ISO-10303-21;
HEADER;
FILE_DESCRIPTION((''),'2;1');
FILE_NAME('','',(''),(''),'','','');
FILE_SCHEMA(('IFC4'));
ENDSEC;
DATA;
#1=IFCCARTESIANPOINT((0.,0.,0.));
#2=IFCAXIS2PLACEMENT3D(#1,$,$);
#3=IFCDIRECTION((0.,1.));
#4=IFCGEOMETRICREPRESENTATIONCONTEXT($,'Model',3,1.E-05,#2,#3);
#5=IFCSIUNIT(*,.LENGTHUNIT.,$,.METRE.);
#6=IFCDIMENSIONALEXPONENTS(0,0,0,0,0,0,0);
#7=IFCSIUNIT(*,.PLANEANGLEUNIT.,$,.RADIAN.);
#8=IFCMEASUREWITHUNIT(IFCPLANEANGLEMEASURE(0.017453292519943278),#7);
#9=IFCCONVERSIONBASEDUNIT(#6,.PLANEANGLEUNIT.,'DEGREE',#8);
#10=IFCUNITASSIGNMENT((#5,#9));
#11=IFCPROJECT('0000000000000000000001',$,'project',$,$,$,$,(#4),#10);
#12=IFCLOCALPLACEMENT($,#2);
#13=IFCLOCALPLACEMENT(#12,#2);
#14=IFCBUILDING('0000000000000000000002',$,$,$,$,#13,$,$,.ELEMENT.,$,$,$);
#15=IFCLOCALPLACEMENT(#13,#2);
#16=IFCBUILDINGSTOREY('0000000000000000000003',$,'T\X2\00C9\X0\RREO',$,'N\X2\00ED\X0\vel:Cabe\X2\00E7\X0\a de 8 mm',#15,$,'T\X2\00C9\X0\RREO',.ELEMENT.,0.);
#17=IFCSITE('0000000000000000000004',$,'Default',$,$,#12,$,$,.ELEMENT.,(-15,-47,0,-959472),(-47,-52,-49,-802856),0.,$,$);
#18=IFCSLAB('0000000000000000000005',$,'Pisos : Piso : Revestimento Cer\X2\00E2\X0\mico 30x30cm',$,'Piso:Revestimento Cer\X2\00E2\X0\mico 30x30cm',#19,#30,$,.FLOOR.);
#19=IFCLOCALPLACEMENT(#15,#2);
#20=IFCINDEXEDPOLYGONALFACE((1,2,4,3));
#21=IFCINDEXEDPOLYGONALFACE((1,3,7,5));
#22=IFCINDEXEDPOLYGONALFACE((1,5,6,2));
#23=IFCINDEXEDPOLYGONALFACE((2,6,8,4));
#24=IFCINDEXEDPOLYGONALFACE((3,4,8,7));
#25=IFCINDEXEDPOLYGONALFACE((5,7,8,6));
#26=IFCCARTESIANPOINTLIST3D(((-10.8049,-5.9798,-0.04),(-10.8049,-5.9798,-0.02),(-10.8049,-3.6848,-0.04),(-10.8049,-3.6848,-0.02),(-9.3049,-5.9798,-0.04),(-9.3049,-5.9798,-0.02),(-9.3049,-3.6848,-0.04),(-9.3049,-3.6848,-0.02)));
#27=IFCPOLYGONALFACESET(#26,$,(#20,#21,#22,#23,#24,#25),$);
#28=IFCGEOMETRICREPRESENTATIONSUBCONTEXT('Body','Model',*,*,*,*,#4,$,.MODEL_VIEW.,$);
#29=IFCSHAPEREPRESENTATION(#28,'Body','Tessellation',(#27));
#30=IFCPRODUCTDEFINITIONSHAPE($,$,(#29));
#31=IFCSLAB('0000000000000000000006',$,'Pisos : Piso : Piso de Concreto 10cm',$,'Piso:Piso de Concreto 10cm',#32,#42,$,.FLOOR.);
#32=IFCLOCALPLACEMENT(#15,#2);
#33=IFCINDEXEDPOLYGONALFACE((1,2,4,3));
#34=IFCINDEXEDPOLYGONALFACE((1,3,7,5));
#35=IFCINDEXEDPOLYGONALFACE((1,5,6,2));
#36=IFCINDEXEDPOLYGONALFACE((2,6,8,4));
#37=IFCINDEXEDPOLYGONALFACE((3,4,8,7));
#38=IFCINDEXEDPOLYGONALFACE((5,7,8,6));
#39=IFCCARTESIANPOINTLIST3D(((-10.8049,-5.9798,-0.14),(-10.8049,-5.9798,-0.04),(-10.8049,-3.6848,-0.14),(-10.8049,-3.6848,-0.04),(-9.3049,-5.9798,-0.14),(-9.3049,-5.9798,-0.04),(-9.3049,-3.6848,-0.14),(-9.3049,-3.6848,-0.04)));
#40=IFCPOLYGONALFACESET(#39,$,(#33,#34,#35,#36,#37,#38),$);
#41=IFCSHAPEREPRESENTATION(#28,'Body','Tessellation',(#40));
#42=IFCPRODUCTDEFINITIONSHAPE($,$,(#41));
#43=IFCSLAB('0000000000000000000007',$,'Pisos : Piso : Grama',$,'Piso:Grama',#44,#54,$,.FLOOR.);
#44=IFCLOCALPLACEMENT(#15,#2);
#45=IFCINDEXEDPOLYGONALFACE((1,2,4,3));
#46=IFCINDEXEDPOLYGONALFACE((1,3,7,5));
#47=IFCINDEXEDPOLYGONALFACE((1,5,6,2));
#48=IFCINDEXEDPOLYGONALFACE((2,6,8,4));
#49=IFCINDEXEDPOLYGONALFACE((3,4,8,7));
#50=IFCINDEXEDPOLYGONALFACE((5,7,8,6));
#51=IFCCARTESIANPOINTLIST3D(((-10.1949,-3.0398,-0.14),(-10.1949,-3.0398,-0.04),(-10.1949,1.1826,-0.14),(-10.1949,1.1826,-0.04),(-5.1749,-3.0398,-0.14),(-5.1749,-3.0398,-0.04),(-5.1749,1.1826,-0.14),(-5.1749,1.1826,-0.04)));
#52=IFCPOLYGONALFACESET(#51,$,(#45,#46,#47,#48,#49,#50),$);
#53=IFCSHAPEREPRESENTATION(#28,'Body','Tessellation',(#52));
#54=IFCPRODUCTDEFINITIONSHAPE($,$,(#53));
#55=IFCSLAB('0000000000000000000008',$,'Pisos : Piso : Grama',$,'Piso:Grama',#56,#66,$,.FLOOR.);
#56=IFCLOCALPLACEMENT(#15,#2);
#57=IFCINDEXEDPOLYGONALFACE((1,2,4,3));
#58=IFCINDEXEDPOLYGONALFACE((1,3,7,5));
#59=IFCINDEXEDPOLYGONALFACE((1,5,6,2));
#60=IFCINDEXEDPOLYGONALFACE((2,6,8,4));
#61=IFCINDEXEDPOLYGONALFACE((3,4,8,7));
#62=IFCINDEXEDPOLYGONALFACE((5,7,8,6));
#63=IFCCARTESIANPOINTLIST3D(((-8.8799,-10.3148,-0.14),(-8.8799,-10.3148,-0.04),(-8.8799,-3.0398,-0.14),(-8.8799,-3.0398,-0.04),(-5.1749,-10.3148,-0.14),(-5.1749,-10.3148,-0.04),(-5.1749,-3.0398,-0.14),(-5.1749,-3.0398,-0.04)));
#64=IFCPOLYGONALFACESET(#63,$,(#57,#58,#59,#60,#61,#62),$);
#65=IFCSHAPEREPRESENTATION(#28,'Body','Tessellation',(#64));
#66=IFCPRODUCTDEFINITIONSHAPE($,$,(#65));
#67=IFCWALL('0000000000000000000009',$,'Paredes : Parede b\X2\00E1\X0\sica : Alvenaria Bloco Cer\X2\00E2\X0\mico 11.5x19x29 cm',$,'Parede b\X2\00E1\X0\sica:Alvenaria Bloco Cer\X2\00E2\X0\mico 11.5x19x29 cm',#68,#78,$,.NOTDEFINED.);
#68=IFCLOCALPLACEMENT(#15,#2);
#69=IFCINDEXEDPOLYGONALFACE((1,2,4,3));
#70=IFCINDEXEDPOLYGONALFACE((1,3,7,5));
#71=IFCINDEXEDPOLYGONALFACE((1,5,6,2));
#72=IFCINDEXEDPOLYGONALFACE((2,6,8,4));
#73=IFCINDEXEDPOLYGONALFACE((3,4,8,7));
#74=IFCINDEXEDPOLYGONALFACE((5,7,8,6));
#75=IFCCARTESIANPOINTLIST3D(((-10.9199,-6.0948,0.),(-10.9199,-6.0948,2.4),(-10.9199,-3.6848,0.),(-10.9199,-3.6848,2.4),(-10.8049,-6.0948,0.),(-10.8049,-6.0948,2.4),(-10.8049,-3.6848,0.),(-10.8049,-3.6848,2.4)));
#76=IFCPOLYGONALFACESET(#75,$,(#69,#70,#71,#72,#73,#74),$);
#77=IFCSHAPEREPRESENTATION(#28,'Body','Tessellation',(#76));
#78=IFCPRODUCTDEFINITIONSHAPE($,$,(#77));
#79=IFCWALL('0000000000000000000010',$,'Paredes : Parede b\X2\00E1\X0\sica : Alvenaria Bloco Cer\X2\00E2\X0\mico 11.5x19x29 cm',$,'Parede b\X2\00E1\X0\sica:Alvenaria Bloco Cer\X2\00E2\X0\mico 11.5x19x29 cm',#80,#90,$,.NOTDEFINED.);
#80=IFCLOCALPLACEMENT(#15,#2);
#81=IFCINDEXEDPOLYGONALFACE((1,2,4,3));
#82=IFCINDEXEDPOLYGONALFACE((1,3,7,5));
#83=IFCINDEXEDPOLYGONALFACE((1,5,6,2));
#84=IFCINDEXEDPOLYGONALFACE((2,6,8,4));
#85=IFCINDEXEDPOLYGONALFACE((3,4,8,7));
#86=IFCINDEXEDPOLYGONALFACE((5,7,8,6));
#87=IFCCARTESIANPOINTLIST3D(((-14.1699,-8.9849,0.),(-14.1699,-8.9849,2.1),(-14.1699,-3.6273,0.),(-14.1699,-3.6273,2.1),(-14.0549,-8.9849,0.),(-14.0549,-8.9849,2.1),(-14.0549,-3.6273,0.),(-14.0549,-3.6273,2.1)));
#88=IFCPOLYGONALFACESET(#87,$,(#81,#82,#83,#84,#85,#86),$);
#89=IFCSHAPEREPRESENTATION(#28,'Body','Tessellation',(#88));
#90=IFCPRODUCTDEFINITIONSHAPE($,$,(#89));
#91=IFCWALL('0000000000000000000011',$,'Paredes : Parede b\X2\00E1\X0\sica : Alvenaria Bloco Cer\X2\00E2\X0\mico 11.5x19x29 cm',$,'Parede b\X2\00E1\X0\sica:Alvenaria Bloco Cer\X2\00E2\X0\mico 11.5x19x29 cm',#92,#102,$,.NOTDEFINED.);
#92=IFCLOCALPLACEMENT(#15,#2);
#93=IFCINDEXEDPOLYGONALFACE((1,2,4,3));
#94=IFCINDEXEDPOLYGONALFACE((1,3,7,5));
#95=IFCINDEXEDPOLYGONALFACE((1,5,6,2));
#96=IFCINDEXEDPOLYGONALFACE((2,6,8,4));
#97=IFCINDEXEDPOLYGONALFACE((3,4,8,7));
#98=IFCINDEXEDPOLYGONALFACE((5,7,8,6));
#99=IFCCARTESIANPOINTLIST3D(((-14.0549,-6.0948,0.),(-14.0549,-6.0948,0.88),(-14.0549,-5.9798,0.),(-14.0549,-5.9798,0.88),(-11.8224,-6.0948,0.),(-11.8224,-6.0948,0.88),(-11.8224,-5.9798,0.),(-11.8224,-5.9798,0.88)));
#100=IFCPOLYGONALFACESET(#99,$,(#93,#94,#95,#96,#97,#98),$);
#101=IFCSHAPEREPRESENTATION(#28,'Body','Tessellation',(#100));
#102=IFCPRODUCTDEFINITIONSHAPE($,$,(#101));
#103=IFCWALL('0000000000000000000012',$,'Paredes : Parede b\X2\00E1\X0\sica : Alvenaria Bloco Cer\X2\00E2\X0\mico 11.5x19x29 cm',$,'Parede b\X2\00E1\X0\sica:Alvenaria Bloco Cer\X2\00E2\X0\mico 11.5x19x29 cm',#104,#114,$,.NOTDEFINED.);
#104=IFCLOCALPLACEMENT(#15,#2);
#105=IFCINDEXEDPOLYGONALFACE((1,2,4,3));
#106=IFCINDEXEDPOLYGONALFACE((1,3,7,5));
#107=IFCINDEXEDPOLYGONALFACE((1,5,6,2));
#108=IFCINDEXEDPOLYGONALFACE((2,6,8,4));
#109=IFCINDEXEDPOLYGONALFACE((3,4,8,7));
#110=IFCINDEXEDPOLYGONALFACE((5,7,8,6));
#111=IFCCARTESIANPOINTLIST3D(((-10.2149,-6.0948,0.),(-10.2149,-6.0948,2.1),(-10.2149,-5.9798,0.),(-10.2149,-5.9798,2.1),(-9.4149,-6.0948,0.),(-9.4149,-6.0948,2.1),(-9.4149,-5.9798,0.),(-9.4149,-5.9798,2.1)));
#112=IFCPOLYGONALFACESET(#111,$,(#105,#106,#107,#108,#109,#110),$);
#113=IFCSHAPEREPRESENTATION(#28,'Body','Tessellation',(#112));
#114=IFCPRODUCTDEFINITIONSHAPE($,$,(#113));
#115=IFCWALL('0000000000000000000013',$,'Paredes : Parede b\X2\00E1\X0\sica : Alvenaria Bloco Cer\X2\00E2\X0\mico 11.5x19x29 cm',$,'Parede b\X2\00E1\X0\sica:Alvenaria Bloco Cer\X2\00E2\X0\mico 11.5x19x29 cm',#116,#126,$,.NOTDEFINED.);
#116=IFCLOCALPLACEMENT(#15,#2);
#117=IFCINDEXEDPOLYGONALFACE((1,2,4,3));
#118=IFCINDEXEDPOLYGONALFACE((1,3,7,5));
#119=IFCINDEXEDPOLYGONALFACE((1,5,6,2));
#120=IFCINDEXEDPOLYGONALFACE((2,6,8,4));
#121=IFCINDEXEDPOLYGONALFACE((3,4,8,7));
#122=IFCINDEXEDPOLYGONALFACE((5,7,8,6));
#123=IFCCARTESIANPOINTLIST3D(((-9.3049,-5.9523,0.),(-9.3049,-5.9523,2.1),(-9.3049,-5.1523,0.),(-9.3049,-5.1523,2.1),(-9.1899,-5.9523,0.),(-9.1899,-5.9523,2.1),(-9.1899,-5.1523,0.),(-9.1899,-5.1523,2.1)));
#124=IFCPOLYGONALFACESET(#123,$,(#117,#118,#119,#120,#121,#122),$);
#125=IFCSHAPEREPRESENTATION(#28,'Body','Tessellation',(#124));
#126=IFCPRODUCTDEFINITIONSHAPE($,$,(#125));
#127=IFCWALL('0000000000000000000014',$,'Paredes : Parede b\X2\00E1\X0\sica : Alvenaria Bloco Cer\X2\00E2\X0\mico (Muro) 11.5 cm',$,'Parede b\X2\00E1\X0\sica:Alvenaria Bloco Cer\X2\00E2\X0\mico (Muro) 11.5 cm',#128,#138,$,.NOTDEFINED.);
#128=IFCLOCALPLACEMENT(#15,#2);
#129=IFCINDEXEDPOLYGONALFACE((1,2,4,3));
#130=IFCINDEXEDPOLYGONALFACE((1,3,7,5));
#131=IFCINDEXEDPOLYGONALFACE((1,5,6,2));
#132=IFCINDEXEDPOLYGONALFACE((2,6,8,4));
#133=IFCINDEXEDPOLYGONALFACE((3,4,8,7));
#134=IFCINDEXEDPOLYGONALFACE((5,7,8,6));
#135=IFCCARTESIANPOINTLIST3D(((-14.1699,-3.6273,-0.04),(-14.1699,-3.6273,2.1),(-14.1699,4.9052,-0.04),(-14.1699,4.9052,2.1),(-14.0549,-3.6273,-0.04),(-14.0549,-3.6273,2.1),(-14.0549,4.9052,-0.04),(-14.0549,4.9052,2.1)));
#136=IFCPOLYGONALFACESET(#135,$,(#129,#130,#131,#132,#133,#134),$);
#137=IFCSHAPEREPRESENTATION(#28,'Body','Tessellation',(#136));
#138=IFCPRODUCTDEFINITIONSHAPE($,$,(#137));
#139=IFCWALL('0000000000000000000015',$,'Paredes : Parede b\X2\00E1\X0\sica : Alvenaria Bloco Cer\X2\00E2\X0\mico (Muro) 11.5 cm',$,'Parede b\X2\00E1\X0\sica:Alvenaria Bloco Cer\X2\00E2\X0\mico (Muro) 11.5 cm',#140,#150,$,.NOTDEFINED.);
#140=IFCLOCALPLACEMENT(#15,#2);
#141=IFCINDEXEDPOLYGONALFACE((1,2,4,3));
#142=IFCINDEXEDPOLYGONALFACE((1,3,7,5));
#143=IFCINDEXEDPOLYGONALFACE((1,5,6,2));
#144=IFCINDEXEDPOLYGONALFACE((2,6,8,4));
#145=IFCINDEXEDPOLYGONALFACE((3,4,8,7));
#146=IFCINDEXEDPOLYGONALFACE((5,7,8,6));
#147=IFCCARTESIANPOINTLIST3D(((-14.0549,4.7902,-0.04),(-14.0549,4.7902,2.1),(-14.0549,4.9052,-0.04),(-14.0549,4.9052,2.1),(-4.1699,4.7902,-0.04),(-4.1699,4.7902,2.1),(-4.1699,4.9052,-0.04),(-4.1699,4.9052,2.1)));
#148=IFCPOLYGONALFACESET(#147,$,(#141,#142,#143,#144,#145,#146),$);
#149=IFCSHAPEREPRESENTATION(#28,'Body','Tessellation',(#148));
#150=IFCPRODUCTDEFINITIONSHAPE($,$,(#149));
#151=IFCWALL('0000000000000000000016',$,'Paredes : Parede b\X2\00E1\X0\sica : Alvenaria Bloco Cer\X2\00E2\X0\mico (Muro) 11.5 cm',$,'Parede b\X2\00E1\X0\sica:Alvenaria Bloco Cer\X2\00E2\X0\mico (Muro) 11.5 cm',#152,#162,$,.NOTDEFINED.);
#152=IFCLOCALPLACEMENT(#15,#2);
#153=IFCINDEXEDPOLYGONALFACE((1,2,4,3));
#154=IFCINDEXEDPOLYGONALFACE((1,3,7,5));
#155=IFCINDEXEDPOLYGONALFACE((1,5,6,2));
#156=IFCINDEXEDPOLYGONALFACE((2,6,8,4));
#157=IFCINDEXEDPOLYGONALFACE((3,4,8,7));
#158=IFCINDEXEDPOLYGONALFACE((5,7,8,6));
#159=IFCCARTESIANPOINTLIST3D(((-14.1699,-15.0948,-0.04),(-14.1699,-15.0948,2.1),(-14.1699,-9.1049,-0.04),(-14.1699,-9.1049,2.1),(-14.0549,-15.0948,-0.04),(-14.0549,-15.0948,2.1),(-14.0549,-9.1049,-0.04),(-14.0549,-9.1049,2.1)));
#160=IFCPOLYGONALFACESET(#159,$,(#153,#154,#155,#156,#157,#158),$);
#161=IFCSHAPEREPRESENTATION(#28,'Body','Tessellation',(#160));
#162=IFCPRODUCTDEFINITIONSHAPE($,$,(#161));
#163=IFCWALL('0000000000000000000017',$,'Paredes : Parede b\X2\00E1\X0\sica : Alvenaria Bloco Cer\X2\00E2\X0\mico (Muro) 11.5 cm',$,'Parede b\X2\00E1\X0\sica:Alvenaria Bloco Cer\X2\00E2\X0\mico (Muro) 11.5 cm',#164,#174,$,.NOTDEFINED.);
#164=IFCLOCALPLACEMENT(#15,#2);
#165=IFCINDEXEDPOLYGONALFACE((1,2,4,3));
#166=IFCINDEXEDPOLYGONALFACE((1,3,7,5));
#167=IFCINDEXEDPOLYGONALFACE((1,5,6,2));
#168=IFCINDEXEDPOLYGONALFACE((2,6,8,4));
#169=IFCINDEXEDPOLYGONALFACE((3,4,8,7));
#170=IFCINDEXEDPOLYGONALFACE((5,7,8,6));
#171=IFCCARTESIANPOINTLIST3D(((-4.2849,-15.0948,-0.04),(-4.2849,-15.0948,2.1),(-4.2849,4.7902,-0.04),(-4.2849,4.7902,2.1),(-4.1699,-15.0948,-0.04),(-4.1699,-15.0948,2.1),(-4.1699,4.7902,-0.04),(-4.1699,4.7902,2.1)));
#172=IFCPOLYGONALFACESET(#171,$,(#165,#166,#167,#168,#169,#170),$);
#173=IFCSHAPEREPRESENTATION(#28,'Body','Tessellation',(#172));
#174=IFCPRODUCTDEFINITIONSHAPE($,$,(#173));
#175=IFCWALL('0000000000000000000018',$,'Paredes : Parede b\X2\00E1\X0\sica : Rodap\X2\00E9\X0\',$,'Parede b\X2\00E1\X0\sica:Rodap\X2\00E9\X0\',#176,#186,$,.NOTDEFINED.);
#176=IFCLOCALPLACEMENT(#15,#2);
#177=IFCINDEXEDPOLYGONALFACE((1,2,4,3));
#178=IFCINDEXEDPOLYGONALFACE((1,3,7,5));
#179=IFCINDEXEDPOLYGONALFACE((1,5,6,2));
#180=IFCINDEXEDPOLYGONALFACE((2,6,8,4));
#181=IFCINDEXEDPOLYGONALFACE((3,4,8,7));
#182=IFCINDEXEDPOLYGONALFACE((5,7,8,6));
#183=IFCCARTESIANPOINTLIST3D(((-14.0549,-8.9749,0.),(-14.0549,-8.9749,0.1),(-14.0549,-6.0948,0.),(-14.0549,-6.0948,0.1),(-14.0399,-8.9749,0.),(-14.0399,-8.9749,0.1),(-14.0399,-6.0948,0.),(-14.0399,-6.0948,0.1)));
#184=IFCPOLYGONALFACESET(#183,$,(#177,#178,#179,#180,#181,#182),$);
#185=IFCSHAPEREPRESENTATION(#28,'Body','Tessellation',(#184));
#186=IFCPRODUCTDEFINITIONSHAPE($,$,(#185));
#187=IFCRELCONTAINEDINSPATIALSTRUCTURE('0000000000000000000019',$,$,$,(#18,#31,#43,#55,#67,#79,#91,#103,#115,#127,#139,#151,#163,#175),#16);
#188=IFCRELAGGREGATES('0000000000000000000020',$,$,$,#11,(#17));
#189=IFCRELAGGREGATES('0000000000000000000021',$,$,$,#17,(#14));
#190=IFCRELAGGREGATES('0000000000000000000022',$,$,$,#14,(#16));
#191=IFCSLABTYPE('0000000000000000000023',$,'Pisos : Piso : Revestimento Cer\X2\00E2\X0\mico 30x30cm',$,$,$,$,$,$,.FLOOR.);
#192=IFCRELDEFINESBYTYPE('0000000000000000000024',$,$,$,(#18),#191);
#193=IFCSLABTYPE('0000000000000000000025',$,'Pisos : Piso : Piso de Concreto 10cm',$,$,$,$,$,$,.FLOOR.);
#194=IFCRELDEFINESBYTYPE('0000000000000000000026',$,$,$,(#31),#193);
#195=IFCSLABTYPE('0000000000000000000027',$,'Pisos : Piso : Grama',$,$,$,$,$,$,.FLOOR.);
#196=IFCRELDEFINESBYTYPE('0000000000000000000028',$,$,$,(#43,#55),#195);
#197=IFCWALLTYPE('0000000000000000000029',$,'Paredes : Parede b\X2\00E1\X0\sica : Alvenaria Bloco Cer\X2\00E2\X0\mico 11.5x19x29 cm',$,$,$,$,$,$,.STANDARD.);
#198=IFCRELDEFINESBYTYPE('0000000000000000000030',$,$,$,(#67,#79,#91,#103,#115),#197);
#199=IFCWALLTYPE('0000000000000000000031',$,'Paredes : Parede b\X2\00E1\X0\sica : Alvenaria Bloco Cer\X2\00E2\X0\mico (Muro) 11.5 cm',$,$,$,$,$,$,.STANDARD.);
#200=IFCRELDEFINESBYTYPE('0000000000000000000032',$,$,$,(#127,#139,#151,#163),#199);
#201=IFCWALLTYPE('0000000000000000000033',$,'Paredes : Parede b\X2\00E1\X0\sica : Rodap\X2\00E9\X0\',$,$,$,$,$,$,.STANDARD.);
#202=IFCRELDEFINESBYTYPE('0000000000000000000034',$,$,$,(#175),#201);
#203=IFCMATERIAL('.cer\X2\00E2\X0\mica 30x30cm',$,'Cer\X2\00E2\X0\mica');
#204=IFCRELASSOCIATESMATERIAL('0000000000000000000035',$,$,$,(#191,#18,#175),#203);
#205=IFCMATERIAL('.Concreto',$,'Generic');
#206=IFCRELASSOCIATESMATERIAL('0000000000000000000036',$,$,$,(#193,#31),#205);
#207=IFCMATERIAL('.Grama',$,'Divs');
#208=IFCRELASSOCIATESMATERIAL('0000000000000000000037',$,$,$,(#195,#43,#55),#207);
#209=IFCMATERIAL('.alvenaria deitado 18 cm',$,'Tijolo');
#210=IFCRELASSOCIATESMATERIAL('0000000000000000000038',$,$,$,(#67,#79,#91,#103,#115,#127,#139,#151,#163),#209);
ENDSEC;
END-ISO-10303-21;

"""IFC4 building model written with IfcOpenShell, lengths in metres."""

from ifc_helpers import new_model, entity, si_unit, converted_unit, direction, frame, origin, place, context, subcontext, project, spatial, indexed_curve, outline, extrude, material, type_object, element, save


model = new_model("IFC4")

# Units and contexts
model_context = context("Model", 3, precision=1e-05, world=origin(), true_north=direction((0.0, 1.0)))
body_context = subcontext(model_context, "Body", "Model", "MODEL_VIEW")
ifc_project = project(units=[si_unit("LENGTHUNIT", "METRE"), converted_unit("PLANEANGLEUNIT", "DEGREE", entity("IfcPlaneAngleMeasure", 0.017453292519943278), si_unit("PLANEANGLEUNIT", "RADIAN"), dimensions=[0, 0, 0, 0, 0, 0, 0])], contexts=[model_context])

# Site, building, storey
site_placement = place(None, origin())
site = spatial("IfcSite", under=ifc_project, at=site_placement, Name="Default", CompositionType="ELEMENT", RefLatitude=(-15, -47, 0, -959472), RefLongitude=(-47, -52, -49, -802856), RefElevation=0.0)
building_placement = place(site_placement, origin())
building = spatial("IfcBuilding", under=site, at=building_placement, CompositionType="ELEMENT")
storey_placement = place(building_placement, origin())
storey = spatial("IfcBuildingStorey", under=building, at=storey_placement, Name="TÉRREO", ObjectType="Nível:Cabeça de 8 mm", LongName="TÉRREO", CompositionType="ELEMENT", Elevation=0.0)

# Slabs
ifc_material_1 = material(Name=".cerâmica 30x30cm", Category="Cerâmica")
slab_type_1 = type_object("IfcSlabType", Name="Pisos : Piso : Revestimento Cerâmico 30x30cm", PredefinedType="FLOOR", material=ifc_material_1)
slab_1_placement = place(storey_placement, origin())
element("IfcSlab", 1, at=slab_1_placement, inside=storey, type_object=slab_type_1, material=ifc_material_1, Name="Pisos : Piso : Revestimento Cerâmico 30x30cm", ObjectType="Piso:Revestimento Cerâmico 30x30cm", PredefinedType="FLOOR", context=body_context, shape_type="SweptSolid", body=[
    extrude(outline(indexed_curve([(-1.1475, -0.75), (1.1475, -0.75), (1.1475, 0.75), (-1.1475, 0.75), (-1.1475, -0.75)], self_intersect=False)), frame((-10.0549, -4.8323, -0.02), z_axis=(0.0, 0.0, -1.0), x_axis=(0.0, 1.0, 0.0)), (0.0, 0.0, 1.0), 0.02),
])
ifc_material_2 = material(Name=".Concreto", Category="Generic")
slab_type_2 = type_object("IfcSlabType", Name="Pisos : Piso : Piso de Concreto 10cm", PredefinedType="FLOOR", material=ifc_material_2)
slab_2_placement = place(storey_placement, origin())
element("IfcSlab", 2, at=slab_2_placement, inside=storey, type_object=slab_type_2, material=ifc_material_2, Name="Pisos : Piso : Piso de Concreto 10cm", ObjectType="Piso:Piso de Concreto 10cm", PredefinedType="FLOOR", context=body_context, shape_type="SweptSolid", body=[
    extrude(outline(indexed_curve([(-1.1475, -0.75), (1.1475, -0.75), (1.1475, 0.75), (-1.1475, 0.75), (-1.1475, -0.75)], self_intersect=False)), frame((-10.0549, -4.8323, -0.04), z_axis=(0.0, 0.0, -1.0), x_axis=(0.0, 1.0, 0.0)), (0.0, 0.0, 1.0), 0.1),
])
ifc_material_3 = material(Name=".Grama", Category="Divs")
slab_type_3 = type_object("IfcSlabType", Name="Pisos : Piso : Grama", PredefinedType="FLOOR", material=ifc_material_3)
slab_3_placement = place(storey_placement, origin())
element("IfcSlab", 3, at=slab_3_placement, inside=storey, type_object=slab_type_3, material=ifc_material_3, Name="Pisos : Piso : Grama", ObjectType="Piso:Grama", PredefinedType="FLOOR", context=body_context, shape_type="SweptSolid", body=[
    extrude(outline(indexed_curve([(-2.1112, -2.51), (2.1112, -2.51), (2.1112, 2.51), (-2.1112, 2.51), (-2.1112, -2.51)], self_intersect=False)), frame((-7.6849, -0.9286, -0.04), z_axis=(0.0, 0.0, -1.0), x_axis=(0.0, 1.0, 0.0)), (0.0, 0.0, 1.0), 0.1),
])
slab_4_placement = place(storey_placement, origin())
element("IfcSlab", 4, at=slab_4_placement, inside=storey, type_object=slab_type_3, material=ifc_material_3, Name="Pisos : Piso : Grama", ObjectType="Piso:Grama", PredefinedType="FLOOR", context=body_context, shape_type="SweptSolid", body=[
    extrude(outline(indexed_curve([(-3.6375, -1.8525), (3.6375, -1.8525), (3.6375, 1.8525), (-3.6375, 1.8525), (-3.6375, -1.8525)], self_intersect=False)), frame((-7.0274, -6.6773, -0.04), z_axis=(0.0, 0.0, -1.0), x_axis=(0.0, 1.0, 0.0)), (0.0, 0.0, 1.0), 0.1),
])

# Walls
ifc_material_4 = material(Name=".alvenaria deitado 18 cm", Category="Tijolo")
wall_type_1 = type_object("IfcWallType", Name="Paredes : Parede básica : Alvenaria Bloco Cerâmico 11.5x19x29 cm", PredefinedType="STANDARD")
wall_1_placement = place(storey_placement, frame((-10.8624, -3.6848, 0.0), z_axis=(0.0, 0.0, 1.0), x_axis=(0.0, -1.0, 0.0)))
element("IfcWall", 5, at=wall_1_placement, inside=storey, type_object=wall_type_1, material=ifc_material_4, Name="Paredes : Parede básica : Alvenaria Bloco Cerâmico 11.5x19x29 cm", ObjectType="Parede básica:Alvenaria Bloco Cerâmico 11.5x19x29 cm", PredefinedType="NOTDEFINED", context=body_context, shape_type="SweptSolid", body=[
    extrude(outline(indexed_curve([(2.41, 0.0575), (0.0, 0.0575), (0.0, -0.0575), (2.41, -0.0575), (2.41, 0.0575)], self_intersect=False)), origin(), (0.0, 0.0, 1.0), 2.4),
])
wall_2_placement = place(storey_placement, frame((-14.1124, -8.9849, 0.0), z_axis=(0.0, 0.0, 1.0), x_axis=(0.0, 1.0, 0.0)))
element("IfcWall", 6, at=wall_2_placement, inside=storey, type_object=wall_type_1, material=ifc_material_4, Name="Paredes : Parede básica : Alvenaria Bloco Cerâmico 11.5x19x29 cm", ObjectType="Parede básica:Alvenaria Bloco Cerâmico 11.5x19x29 cm", PredefinedType="NOTDEFINED", context=body_context, shape_type="SweptSolid", body=[
    extrude(outline(indexed_curve([(5.3576, 0.0575), (0.0, 0.0575), (0.0, -0.0575), (5.3576, -0.0575), (5.3576, 0.0575)], self_intersect=False)), origin(), (0.0, 0.0, 1.0), 2.1),
])
wall_3_placement = place(storey_placement, frame((-14.0549, -6.0373, 0.0)))
element("IfcWall", 7, at=wall_3_placement, inside=storey, type_object=wall_type_1, material=ifc_material_4, Name="Paredes : Parede básica : Alvenaria Bloco Cerâmico 11.5x19x29 cm", ObjectType="Parede básica:Alvenaria Bloco Cerâmico 11.5x19x29 cm", PredefinedType="NOTDEFINED", context=body_context, shape_type="SweptSolid", body=[
    extrude(outline(indexed_curve([(2.2325, 0.0575), (0.0, 0.0575), (0.0, -0.0575), (2.2325, -0.0575), (2.2325, 0.0575)], self_intersect=False)), origin(), (0.0, 0.0, 1.0), 0.88),
])
wall_4_placement = place(storey_placement, frame((-10.2149, -6.0373, 0.0)))
element("IfcWall", 8, at=wall_4_placement, inside=storey, type_object=wall_type_1, material=ifc_material_4, Name="Paredes : Parede básica : Alvenaria Bloco Cerâmico 11.5x19x29 cm", ObjectType="Parede básica:Alvenaria Bloco Cerâmico 11.5x19x29 cm", PredefinedType="NOTDEFINED", context=body_context, shape_type="SweptSolid", body=[
    extrude(outline(indexed_curve([(0.8, 0.0575), (0.0, 0.0575), (0.0, -0.0575), (0.8, -0.0575), (0.8, 0.0575)], self_intersect=False)), origin(), (0.0, 0.0, 1.0), 2.1),
])
wall_5_placement = place(storey_placement, frame((-9.2474, -5.9523, 0.0), z_axis=(0.0, 0.0, 1.0), x_axis=(0.0, 1.0, 0.0)))
element("IfcWall", 9, at=wall_5_placement, inside=storey, type_object=wall_type_1, material=ifc_material_4, Name="Paredes : Parede básica : Alvenaria Bloco Cerâmico 11.5x19x29 cm", ObjectType="Parede básica:Alvenaria Bloco Cerâmico 11.5x19x29 cm", PredefinedType="NOTDEFINED", context=body_context, shape_type="SweptSolid", body=[
    extrude(outline(indexed_curve([(0.8, 0.0575), (0.0, 0.0575), (0.0, -0.0575), (0.8, -0.0575), (0.8, 0.0575)], self_intersect=False)), origin(), (0.0, 0.0, 1.0), 2.1),
])
wall_type_2 = type_object("IfcWallType", Name="Paredes : Parede básica : Alvenaria Bloco Cerâmico (Muro) 11.5 cm", PredefinedType="STANDARD")
wall_6_placement = place(storey_placement, frame((-14.1124, -3.6273, -0.04), z_axis=(0.0, 0.0, 1.0), x_axis=(0.0, 1.0, 0.0)))
element("IfcWall", 10, at=wall_6_placement, inside=storey, type_object=wall_type_2, material=ifc_material_4, Name="Paredes : Parede básica : Alvenaria Bloco Cerâmico (Muro) 11.5 cm", ObjectType="Parede básica:Alvenaria Bloco Cerâmico (Muro) 11.5 cm", PredefinedType="NOTDEFINED", context=body_context, shape_type="SweptSolid", body=[
    extrude(outline(indexed_curve([(8.5325, 0.0575), (0.0, 0.0575), (0.0, -0.0575), (8.5325, -0.0575), (8.5325, 0.0575)], self_intersect=False)), origin(), (0.0, 0.0, 1.0), 2.14),
])
wall_7_placement = place(storey_placement, frame((-14.0549, 4.8477, -0.04)))
element("IfcWall", 11, at=wall_7_placement, inside=storey, type_object=wall_type_2, material=ifc_material_4, Name="Paredes : Parede básica : Alvenaria Bloco Cerâmico (Muro) 11.5 cm", ObjectType="Parede básica:Alvenaria Bloco Cerâmico (Muro) 11.5 cm", PredefinedType="NOTDEFINED", context=body_context, shape_type="SweptSolid", body=[
    extrude(outline(indexed_curve([(9.885, 0.0575), (0.0, 0.0575), (0.0, -0.0575), (9.885, -0.0575), (9.885, 0.0575)], self_intersect=False)), origin(), (0.0, 0.0, 1.0), 2.14),
])
wall_8_placement = place(storey_placement, frame((-14.1124, -9.1049, -0.04), z_axis=(0.0, 0.0, 1.0), x_axis=(0.0, -1.0, 0.0)))
element("IfcWall", 12, at=wall_8_placement, inside=storey, type_object=wall_type_2, material=ifc_material_4, Name="Paredes : Parede básica : Alvenaria Bloco Cerâmico (Muro) 11.5 cm", ObjectType="Parede básica:Alvenaria Bloco Cerâmico (Muro) 11.5 cm", PredefinedType="NOTDEFINED", context=body_context, shape_type="SweptSolid", body=[
    extrude(outline(indexed_curve([(5.9899, 0.0575), (0.0, 0.0575), (0.0, -0.0575), (5.9899, -0.0575), (5.9899, 0.0575)], self_intersect=False)), origin(), (0.0, 0.0, 1.0), 2.14),
])
wall_9_placement = place(storey_placement, frame((-4.2274, 4.7902, -0.04), z_axis=(0.0, 0.0, 1.0), x_axis=(0.0, -1.0, 0.0)))
element("IfcWall", 13, at=wall_9_placement, inside=storey, type_object=wall_type_2, material=ifc_material_4, Name="Paredes : Parede básica : Alvenaria Bloco Cerâmico (Muro) 11.5 cm", ObjectType="Parede básica:Alvenaria Bloco Cerâmico (Muro) 11.5 cm", PredefinedType="NOTDEFINED", context=body_context, shape_type="SweptSolid", body=[
    extrude(outline(indexed_curve([(19.885, 0.0575), (0.0, 0.0575), (0.0, -0.0575), (19.885, -0.0575), (19.885, 0.0575)], self_intersect=False)), origin(), (0.0, 0.0, 1.0), 2.14),
])
wall_type_3 = type_object("IfcWallType", Name="Paredes : Parede básica : Rodapé", PredefinedType="STANDARD")
wall_10_placement = place(storey_placement, frame((-14.0474, -8.9749, 0.0), z_axis=(0.0, 0.0, 1.0), x_axis=(0.0, 1.0, 0.0)))
element("IfcWall", 14, at=wall_10_placement, inside=storey, type_object=wall_type_3, material=ifc_material_1, Name="Paredes : Parede básica : Rodapé", ObjectType="Parede básica:Rodapé", PredefinedType="NOTDEFINED", context=body_context, shape_type="SweptSolid", body=[
    extrude(outline(indexed_curve([(2.8801, 0.0075), (0.0, 0.0075), (0.0, -0.0075), (2.8801, -0.0075), (2.8801, 0.0075)], self_intersect=False)), origin(), (0.0, 0.0, 1.0), 0.1),
])

save(model, "model.ifc")
